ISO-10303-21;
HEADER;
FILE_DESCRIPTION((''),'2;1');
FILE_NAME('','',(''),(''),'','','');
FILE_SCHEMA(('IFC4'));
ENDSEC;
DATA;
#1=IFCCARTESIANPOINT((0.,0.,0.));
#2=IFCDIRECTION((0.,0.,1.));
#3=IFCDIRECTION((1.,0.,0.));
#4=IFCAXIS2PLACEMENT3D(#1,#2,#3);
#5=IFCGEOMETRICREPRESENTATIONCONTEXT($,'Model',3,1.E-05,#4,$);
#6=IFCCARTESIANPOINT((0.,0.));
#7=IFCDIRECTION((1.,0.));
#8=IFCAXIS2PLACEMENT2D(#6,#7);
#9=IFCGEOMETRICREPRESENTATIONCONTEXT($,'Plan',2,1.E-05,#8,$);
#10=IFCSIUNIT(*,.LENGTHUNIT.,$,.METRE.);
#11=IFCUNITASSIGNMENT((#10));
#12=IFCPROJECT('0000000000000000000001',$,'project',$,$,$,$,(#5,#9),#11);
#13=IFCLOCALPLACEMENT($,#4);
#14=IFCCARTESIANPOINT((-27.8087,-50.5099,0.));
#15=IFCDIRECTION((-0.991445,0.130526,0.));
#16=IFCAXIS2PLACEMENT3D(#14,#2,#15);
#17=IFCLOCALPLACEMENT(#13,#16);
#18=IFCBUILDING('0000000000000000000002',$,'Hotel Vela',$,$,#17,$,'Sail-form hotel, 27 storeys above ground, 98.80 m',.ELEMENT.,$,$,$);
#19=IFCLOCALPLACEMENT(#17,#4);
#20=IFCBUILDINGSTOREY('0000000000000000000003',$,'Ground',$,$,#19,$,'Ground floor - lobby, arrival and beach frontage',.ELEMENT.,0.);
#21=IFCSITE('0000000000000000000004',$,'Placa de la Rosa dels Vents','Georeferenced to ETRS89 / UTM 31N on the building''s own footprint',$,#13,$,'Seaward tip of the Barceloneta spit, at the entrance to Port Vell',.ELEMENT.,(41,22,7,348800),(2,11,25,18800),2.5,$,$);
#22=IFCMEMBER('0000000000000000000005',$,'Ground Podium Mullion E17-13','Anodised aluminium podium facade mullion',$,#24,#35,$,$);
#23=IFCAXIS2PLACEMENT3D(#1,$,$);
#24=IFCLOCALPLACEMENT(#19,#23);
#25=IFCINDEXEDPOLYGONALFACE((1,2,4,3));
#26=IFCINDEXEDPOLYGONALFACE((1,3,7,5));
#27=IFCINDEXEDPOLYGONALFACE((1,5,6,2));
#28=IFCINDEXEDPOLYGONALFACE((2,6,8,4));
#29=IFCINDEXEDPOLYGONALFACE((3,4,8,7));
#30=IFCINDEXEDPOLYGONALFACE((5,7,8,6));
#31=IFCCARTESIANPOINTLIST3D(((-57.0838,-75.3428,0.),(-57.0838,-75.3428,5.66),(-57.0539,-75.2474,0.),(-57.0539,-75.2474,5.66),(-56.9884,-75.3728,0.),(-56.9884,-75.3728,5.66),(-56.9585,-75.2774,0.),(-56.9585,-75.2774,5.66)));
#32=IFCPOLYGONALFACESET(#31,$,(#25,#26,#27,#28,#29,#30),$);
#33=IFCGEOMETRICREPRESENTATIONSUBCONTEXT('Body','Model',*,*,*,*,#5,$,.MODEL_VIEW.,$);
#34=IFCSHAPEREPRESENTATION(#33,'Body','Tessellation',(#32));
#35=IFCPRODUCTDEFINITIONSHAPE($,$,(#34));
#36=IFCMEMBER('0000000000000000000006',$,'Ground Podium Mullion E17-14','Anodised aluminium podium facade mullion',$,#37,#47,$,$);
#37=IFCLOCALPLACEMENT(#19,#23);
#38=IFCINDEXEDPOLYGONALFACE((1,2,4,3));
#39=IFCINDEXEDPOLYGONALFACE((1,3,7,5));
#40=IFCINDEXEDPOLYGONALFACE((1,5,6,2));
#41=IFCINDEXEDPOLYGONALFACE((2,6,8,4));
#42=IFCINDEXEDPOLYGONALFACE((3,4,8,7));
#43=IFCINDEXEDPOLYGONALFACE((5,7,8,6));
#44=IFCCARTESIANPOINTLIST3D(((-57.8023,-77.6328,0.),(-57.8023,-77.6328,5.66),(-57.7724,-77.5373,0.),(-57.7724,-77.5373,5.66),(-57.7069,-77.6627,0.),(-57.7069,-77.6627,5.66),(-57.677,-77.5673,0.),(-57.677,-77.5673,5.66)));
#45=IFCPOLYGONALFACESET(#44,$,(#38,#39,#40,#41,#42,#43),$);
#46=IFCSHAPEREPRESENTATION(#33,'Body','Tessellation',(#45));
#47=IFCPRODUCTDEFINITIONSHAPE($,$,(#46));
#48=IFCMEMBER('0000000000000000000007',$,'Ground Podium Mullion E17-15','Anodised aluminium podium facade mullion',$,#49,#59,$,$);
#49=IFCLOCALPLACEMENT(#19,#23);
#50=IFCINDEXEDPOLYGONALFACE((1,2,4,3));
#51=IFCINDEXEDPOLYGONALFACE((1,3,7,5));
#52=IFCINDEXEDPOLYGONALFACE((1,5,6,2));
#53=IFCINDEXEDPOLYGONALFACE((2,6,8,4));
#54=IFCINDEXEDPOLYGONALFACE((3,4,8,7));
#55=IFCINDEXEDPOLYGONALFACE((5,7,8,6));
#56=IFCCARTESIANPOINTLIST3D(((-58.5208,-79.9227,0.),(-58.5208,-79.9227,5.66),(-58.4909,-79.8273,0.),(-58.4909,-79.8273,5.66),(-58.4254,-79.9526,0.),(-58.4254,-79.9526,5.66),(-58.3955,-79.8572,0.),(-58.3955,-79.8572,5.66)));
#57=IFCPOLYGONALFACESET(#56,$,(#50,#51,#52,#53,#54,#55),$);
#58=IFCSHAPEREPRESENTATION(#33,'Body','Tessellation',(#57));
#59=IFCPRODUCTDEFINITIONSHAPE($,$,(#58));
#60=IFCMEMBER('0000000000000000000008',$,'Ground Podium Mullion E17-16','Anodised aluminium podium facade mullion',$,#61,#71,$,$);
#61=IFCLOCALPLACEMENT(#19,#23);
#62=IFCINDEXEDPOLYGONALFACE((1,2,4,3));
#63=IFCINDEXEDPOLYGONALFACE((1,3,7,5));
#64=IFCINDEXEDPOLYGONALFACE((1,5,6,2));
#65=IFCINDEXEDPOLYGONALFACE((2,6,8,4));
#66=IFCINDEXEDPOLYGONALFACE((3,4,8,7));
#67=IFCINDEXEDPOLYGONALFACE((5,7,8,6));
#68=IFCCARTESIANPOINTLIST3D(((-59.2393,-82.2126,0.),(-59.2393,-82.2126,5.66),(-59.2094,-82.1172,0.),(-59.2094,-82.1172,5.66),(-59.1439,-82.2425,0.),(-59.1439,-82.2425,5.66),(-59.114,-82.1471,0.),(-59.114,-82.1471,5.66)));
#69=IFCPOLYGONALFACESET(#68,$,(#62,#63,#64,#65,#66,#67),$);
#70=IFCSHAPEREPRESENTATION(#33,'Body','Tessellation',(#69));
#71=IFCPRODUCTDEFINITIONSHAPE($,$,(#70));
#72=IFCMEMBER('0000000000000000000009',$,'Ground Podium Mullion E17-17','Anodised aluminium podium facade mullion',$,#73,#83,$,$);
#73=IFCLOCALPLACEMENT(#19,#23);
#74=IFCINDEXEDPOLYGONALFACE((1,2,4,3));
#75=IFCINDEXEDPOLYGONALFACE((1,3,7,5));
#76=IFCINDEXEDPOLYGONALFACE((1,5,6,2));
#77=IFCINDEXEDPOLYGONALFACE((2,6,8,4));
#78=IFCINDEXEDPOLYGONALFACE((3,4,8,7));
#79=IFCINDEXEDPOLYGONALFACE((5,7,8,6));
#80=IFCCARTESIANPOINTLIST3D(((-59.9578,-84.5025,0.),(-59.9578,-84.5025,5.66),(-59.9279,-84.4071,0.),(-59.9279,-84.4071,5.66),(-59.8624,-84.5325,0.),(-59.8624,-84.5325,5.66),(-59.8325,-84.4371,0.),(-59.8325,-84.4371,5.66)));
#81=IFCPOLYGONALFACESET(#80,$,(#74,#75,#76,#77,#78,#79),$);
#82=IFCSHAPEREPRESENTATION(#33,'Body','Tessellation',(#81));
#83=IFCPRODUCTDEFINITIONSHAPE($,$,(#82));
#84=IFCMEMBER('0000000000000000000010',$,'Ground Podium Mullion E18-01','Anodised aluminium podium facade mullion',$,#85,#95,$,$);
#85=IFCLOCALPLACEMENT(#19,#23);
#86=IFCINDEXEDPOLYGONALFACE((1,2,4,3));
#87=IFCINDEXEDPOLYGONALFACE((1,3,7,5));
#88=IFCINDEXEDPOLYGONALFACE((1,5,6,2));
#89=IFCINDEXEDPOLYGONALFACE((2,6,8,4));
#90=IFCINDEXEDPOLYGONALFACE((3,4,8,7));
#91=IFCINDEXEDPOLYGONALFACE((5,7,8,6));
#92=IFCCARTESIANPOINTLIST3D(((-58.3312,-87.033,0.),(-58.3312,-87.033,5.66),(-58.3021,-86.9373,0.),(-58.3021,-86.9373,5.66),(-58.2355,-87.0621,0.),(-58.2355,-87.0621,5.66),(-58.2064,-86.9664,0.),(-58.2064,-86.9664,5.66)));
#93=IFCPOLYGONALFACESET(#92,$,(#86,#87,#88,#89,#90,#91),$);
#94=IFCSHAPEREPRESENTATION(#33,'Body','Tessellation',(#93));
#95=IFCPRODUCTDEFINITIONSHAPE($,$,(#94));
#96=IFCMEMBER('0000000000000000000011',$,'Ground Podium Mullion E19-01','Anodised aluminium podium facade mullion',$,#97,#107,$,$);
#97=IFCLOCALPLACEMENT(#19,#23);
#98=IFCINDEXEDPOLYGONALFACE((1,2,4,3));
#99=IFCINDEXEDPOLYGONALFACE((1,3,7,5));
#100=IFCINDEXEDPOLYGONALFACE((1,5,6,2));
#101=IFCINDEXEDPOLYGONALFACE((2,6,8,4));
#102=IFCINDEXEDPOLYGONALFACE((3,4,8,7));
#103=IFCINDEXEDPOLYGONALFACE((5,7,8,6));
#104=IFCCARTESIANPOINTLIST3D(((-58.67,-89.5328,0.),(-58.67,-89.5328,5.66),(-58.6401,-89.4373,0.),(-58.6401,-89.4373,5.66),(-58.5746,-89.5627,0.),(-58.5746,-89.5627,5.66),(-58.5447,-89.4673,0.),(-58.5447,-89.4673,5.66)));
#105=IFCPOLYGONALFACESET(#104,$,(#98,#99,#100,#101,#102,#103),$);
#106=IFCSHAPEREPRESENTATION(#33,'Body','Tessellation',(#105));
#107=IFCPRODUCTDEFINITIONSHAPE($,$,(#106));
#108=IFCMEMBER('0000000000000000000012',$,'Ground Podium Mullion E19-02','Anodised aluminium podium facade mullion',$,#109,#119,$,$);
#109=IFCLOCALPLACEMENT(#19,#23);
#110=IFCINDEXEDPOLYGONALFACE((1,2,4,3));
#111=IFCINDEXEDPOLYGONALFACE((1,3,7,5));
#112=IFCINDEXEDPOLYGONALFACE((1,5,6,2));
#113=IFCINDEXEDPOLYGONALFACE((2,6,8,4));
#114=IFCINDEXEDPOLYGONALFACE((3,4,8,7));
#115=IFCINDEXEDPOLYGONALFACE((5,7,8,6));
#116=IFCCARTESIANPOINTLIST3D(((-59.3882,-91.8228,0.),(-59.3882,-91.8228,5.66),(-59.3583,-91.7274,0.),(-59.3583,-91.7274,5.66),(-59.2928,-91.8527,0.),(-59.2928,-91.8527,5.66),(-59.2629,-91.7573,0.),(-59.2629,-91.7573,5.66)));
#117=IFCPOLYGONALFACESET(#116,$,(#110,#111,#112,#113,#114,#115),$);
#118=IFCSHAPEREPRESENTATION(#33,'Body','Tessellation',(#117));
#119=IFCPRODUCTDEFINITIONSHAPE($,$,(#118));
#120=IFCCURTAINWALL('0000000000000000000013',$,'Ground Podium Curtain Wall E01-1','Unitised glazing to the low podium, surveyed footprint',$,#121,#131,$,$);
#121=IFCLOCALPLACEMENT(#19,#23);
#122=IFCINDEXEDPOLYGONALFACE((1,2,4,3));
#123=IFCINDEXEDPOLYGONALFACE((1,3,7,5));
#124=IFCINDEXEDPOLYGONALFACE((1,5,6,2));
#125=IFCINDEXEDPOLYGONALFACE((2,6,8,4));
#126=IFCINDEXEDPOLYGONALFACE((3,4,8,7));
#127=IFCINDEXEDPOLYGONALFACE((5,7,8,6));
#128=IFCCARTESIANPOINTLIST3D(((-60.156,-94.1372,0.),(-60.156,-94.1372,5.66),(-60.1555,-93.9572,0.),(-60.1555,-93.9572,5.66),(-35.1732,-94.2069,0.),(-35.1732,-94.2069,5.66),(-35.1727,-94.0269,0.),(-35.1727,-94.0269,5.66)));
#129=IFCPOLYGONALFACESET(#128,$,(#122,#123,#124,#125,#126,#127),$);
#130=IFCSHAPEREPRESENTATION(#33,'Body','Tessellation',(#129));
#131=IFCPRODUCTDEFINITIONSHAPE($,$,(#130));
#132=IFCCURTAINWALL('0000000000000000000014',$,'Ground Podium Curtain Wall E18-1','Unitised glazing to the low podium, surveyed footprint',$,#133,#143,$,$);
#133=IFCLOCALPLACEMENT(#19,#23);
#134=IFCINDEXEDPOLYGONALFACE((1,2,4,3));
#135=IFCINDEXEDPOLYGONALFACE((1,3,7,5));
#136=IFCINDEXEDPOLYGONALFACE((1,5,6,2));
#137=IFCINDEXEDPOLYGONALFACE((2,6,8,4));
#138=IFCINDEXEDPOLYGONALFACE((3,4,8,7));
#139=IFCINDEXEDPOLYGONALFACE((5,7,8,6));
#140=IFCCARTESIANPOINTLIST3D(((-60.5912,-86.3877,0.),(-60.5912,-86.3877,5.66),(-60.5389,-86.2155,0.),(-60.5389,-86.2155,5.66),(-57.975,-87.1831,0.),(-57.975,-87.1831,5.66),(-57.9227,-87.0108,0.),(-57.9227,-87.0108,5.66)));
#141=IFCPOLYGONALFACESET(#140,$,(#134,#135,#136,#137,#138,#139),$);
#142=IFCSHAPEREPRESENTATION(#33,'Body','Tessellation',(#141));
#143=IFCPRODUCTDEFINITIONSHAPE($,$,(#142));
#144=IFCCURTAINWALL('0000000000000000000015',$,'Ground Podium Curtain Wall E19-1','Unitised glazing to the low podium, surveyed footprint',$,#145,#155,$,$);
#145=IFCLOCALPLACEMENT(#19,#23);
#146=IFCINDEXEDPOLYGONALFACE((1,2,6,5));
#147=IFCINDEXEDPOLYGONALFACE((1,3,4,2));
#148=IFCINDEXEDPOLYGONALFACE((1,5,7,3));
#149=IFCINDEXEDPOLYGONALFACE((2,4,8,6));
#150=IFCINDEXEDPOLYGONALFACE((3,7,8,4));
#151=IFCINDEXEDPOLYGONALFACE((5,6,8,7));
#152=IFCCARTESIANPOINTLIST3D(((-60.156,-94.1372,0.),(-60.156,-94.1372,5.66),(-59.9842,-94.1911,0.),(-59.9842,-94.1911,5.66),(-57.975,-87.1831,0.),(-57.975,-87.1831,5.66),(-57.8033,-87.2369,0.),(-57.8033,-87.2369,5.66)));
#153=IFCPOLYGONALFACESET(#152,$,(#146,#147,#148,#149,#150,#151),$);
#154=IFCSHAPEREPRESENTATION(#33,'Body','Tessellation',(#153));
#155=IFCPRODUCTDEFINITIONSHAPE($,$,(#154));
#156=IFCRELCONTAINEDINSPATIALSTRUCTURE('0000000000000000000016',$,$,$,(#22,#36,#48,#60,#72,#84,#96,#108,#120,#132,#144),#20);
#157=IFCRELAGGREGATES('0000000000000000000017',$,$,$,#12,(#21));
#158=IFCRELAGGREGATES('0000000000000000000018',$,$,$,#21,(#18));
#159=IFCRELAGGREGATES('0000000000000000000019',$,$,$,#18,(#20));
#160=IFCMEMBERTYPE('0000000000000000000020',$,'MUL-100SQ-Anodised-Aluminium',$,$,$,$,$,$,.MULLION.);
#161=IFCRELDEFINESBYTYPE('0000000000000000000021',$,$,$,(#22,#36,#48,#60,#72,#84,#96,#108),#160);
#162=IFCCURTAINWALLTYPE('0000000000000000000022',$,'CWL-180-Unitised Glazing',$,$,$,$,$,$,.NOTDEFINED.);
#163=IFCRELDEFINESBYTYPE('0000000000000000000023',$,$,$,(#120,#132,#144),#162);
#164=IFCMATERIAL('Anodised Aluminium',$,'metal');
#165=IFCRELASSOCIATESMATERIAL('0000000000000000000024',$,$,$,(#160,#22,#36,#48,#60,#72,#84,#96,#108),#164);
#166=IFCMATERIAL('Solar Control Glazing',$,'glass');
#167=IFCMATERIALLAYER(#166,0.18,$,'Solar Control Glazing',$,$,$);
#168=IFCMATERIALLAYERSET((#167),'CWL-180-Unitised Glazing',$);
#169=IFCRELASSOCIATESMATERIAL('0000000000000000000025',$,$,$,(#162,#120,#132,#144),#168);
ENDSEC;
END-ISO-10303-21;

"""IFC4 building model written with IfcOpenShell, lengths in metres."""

from ifc_helpers import new_model, si_unit, frame, origin_with_axes, origin_2d_with_axis, place, context, subcontext, project, spatial, line, indexed_curve, rectangle, outline, extrude, material, layer, layer_set, layer_usage, material_profile, profile_set, profile_usage, type_object, element, save


model = new_model("IFC4")

# Units and contexts
model_context = context("Model", 3, precision=1e-05, world=origin_with_axes())
plan_context = context("Plan", 2, precision=1e-05, world=origin_2d_with_axis())
body_context = subcontext(model_context, "Body", "Model", "MODEL_VIEW")
ifc_project = project(units=[si_unit("LENGTHUNIT", "METRE")], contexts=[model_context, plan_context])

# Site, building, storey
site_placement = place(None, origin_with_axes())
site = spatial("IfcSite", under=ifc_project, at=site_placement, Name="Placa de la Rosa dels Vents", Description="Georeferenced to ETRS89 / UTM 31N on the building's own footprint", LongName="Seaward tip of the Barceloneta spit, at the entrance to Port Vell", CompositionType="ELEMENT", RefLatitude=(41, 22, 7, 348800), RefLongitude=(2, 11, 25, 18800), RefElevation=2.5)
building_placement = place(site_placement, frame((-27.8087, -50.5099, 0.0), z_axis=(0.0, 0.0, 1.0), x_axis=(-0.991445, 0.130526, 0.0)))
building = spatial("IfcBuilding", under=site, at=building_placement, Name="Hotel Vela", LongName="Sail-form hotel, 27 storeys above ground, 98.80 m", CompositionType="ELEMENT")
storey_placement = place(building_placement, origin_with_axes())
storey = spatial("IfcBuildingStorey", under=building, at=storey_placement, Name="Ground", LongName="Ground floor - lobby, arrival and beach frontage", CompositionType="ELEMENT", Elevation=0.0)

# Members
ifc_material_1 = material(Name="Anodised Aluminium", Category="metal")
ifc_material_profile = material_profile(ifc_material_1, rectangle(XDim=0.1, YDim=0.1))
ifc_profile_set = profile_set([ifc_material_profile], Name="MUL-100SQ-Anodised-Aluminium")
member_type = type_object("IfcMemberType", Name="MUL-100SQ-Anodised-Aluminium", PredefinedType="MULLION", material=ifc_profile_set)
ifc_profile_usage_1 = profile_usage(ifc_profile_set)
member_1_placement = place(storey_placement, frame((-57.0539, -75.2474, 0.0), z_axis=(0.0, 0.0, 1.0), x_axis=(-0.299373, -0.954136, 0.0)))
element("IfcMember", 1, at=member_1_placement, inside=storey, type_object=member_type, material=ifc_profile_usage_1, Name="Ground Podium Mullion E17-13", Description="Anodised aluminium podium facade mullion", context=body_context, shape_type="SweptSolid", body=[
    extrude(outline(indexed_curve([(0.0, 0.0), (0.1, 0.0), (0.1, 0.1), (0.0, 0.1)], segments=[line(1, 2, 3, 4, 1)])), origin_with_axes(), (0.0, 0.0, 1.0), 5.66),
])
ifc_profile_usage_2 = profile_usage(ifc_profile_set)
member_2_placement = place(storey_placement, frame((-57.7724, -77.5373, 0.0), z_axis=(0.0, 0.0, 1.0), x_axis=(-0.299373, -0.954136, 0.0)))
element("IfcMember", 2, at=member_2_placement, inside=storey, type_object=member_type, material=ifc_profile_usage_2, Name="Ground Podium Mullion E17-14", Description="Anodised aluminium podium facade mullion", context=body_context, shape_type="SweptSolid", body=[
    extrude(outline(indexed_curve([(0.0, 0.0), (0.1, 0.0), (0.1, 0.1), (0.0, 0.1)], segments=[line(1, 2, 3, 4, 1)])), origin_with_axes(), (0.0, 0.0, 1.0), 5.66),
])
ifc_profile_usage_3 = profile_usage(ifc_profile_set)
member_3_placement = place(storey_placement, frame((-58.4909, -79.8273, 0.0), z_axis=(0.0, 0.0, 1.0), x_axis=(-0.299373, -0.954136, 0.0)))
element("IfcMember", 3, at=member_3_placement, inside=storey, type_object=member_type, material=ifc_profile_usage_3, Name="Ground Podium Mullion E17-15", Description="Anodised aluminium podium facade mullion", context=body_context, shape_type="SweptSolid", body=[
    extrude(outline(indexed_curve([(0.0, 0.0), (0.1, 0.0), (0.1, 0.1), (0.0, 0.1)], segments=[line(1, 2, 3, 4, 1)])), origin_with_axes(), (0.0, 0.0, 1.0), 5.66),
])
ifc_profile_usage_4 = profile_usage(ifc_profile_set)
member_4_placement = place(storey_placement, frame((-59.2094, -82.1172, 0.0), z_axis=(0.0, 0.0, 1.0), x_axis=(-0.299373, -0.954136, 0.0)))
element("IfcMember", 4, at=member_4_placement, inside=storey, type_object=member_type, material=ifc_profile_usage_4, Name="Ground Podium Mullion E17-16", Description="Anodised aluminium podium facade mullion", context=body_context, shape_type="SweptSolid", body=[
    extrude(outline(indexed_curve([(0.0, 0.0), (0.1, 0.0), (0.1, 0.1), (0.0, 0.1)], segments=[line(1, 2, 3, 4, 1)])), origin_with_axes(), (0.0, 0.0, 1.0), 5.66),
])
ifc_profile_usage_5 = profile_usage(ifc_profile_set)
member_5_placement = place(storey_placement, frame((-59.9279, -84.4071, 0.0), z_axis=(0.0, 0.0, 1.0), x_axis=(-0.299373, -0.954136, 0.0)))
element("IfcMember", 5, at=member_5_placement, inside=storey, type_object=member_type, material=ifc_profile_usage_5, Name="Ground Podium Mullion E17-17", Description="Anodised aluminium podium facade mullion", context=body_context, shape_type="SweptSolid", body=[
    extrude(outline(indexed_curve([(0.0, 0.0), (0.1, 0.0), (0.1, 0.1), (0.0, 0.1)], segments=[line(1, 2, 3, 4, 1)])), origin_with_axes(), (0.0, 0.0, 1.0), 5.66),
])
ifc_profile_usage_6 = profile_usage(ifc_profile_set)
member_6_placement = place(storey_placement, frame((-58.3312, -87.033, 0.0), z_axis=(0.0, 0.0, 1.0), x_axis=(0.956767, -0.290857, 0.0)))
element("IfcMember", 6, at=member_6_placement, inside=storey, type_object=member_type, material=ifc_profile_usage_6, Name="Ground Podium Mullion E18-01", Description="Anodised aluminium podium facade mullion", context=body_context, shape_type="SweptSolid", body=[
    extrude(outline(indexed_curve([(0.0, 0.0), (0.1, 0.0), (0.1, 0.1), (0.0, 0.1)], segments=[line(1, 2, 3, 4, 1)])), origin_with_axes(), (0.0, 0.0, 1.0), 5.66),
])
ifc_profile_usage_7 = profile_usage(ifc_profile_set)
member_7_placement = place(storey_placement, frame((-58.6401, -89.4373, 0.0), z_axis=(0.0, 0.0, 1.0), x_axis=(-0.299247, -0.954176, 0.0)))
element("IfcMember", 7, at=member_7_placement, inside=storey, type_object=member_type, material=ifc_profile_usage_7, Name="Ground Podium Mullion E19-01", Description="Anodised aluminium podium facade mullion", context=body_context, shape_type="SweptSolid", body=[
    extrude(outline(indexed_curve([(0.0, 0.0), (0.1, 0.0), (0.1, 0.1), (0.0, 0.1)], segments=[line(1, 2, 3, 4, 1)])), origin_with_axes(), (0.0, 0.0, 1.0), 5.66),
])
ifc_profile_usage_8 = profile_usage(ifc_profile_set)
member_8_placement = place(storey_placement, frame((-59.3583, -91.7274, 0.0), z_axis=(0.0, 0.0, 1.0), x_axis=(-0.299247, -0.954176, 0.0)))
element("IfcMember", 8, at=member_8_placement, inside=storey, type_object=member_type, material=ifc_profile_usage_8, Name="Ground Podium Mullion E19-02", Description="Anodised aluminium podium facade mullion", context=body_context, shape_type="SweptSolid", body=[
    extrude(outline(indexed_curve([(0.0, 0.0), (0.1, 0.0), (0.1, 0.1), (0.0, 0.1)], segments=[line(1, 2, 3, 4, 1)])), origin_with_axes(), (0.0, 0.0, 1.0), 5.66),
])

# Curtain walls
ifc_material_2 = material(Name="Solar Control Glazing", Category="glass")
ifc_layer = layer(ifc_material_2, 0.18, Name="Solar Control Glazing")
ifc_layer_set = layer_set([ifc_layer], Name="CWL-180-Unitised Glazing")
ifc_layer_usage_1 = layer_usage(ifc_layer_set, "AXIS2", "POSITIVE", 0.0)
curtain_wall_type = type_object("IfcCurtainWallType", Name="CWL-180-Unitised Glazing", PredefinedType="NOTDEFINED", material=ifc_layer_set)
curtain_wall_1_placement = place(storey_placement, frame((-60.156, -94.1372, 0.0), z_axis=(0.0, 0.0, 1.0), x_axis=(0.999996, -0.002789, 0.0)))
element("IfcCurtainWall", 9, at=curtain_wall_1_placement, inside=storey, type_object=curtain_wall_type, material=ifc_layer_usage_1, Name="Ground Podium Curtain Wall E01-1", Description="Unitised glazing to the low podium, surveyed footprint", context=body_context, shape_type="SweptSolid", body=[
    extrude(outline(indexed_curve([(0.0, 0.0), (24.9829, 0.0), (24.9829, 0.18), (0.0, 0.18)], segments=[line(1, 2, 3, 4, 1)])), origin_with_axes(), (0.0, 0.0, 1.0), 5.66),
])
ifc_layer_usage_2 = layer_usage(ifc_layer_set, "AXIS2", "POSITIVE", 0.0)
curtain_wall_2_placement = place(storey_placement, frame((-60.5912, -86.3877, 0.0), z_axis=(0.0, 0.0, 1.0), x_axis=(0.956767, -0.290857, 0.0)))
element("IfcCurtainWall", 10, at=curtain_wall_2_placement, inside=storey, type_object=curtain_wall_type, material=ifc_layer_usage_2, Name="Ground Podium Curtain Wall E18-1", Description="Unitised glazing to the low podium, surveyed footprint", context=body_context, shape_type="SweptSolid", body=[
    extrude(outline(indexed_curve([(0.0, 0.0), (2.7344, 0.0), (2.7344, 0.18), (0.0, 0.18)], segments=[line(1, 2, 3, 4, 1)])), origin_with_axes(), (0.0, 0.0, 1.0), 5.66),
])
ifc_layer_usage_3 = layer_usage(ifc_layer_set, "AXIS2", "POSITIVE", 0.0)
curtain_wall_3_placement = place(storey_placement, frame((-57.975, -87.1831, 0.0), z_axis=(0.0, 0.0, 1.0), x_axis=(-0.299247, -0.954176, 0.0)))
element("IfcCurtainWall", 11, at=curtain_wall_3_placement, inside=storey, type_object=curtain_wall_type, material=ifc_layer_usage_3, Name="Ground Podium Curtain Wall E19-1", Description="Unitised glazing to the low podium, surveyed footprint", context=body_context, shape_type="SweptSolid", body=[
    extrude(outline(indexed_curve([(0.0, 0.0), (7.2881, 0.0), (7.2881, 0.18), (0.0, 0.18)], segments=[line(1, 2, 3, 4, 1)])), origin_with_axes(), (0.0, 0.0, 1.0), 5.66),
])

save(model, "model.ifc")
